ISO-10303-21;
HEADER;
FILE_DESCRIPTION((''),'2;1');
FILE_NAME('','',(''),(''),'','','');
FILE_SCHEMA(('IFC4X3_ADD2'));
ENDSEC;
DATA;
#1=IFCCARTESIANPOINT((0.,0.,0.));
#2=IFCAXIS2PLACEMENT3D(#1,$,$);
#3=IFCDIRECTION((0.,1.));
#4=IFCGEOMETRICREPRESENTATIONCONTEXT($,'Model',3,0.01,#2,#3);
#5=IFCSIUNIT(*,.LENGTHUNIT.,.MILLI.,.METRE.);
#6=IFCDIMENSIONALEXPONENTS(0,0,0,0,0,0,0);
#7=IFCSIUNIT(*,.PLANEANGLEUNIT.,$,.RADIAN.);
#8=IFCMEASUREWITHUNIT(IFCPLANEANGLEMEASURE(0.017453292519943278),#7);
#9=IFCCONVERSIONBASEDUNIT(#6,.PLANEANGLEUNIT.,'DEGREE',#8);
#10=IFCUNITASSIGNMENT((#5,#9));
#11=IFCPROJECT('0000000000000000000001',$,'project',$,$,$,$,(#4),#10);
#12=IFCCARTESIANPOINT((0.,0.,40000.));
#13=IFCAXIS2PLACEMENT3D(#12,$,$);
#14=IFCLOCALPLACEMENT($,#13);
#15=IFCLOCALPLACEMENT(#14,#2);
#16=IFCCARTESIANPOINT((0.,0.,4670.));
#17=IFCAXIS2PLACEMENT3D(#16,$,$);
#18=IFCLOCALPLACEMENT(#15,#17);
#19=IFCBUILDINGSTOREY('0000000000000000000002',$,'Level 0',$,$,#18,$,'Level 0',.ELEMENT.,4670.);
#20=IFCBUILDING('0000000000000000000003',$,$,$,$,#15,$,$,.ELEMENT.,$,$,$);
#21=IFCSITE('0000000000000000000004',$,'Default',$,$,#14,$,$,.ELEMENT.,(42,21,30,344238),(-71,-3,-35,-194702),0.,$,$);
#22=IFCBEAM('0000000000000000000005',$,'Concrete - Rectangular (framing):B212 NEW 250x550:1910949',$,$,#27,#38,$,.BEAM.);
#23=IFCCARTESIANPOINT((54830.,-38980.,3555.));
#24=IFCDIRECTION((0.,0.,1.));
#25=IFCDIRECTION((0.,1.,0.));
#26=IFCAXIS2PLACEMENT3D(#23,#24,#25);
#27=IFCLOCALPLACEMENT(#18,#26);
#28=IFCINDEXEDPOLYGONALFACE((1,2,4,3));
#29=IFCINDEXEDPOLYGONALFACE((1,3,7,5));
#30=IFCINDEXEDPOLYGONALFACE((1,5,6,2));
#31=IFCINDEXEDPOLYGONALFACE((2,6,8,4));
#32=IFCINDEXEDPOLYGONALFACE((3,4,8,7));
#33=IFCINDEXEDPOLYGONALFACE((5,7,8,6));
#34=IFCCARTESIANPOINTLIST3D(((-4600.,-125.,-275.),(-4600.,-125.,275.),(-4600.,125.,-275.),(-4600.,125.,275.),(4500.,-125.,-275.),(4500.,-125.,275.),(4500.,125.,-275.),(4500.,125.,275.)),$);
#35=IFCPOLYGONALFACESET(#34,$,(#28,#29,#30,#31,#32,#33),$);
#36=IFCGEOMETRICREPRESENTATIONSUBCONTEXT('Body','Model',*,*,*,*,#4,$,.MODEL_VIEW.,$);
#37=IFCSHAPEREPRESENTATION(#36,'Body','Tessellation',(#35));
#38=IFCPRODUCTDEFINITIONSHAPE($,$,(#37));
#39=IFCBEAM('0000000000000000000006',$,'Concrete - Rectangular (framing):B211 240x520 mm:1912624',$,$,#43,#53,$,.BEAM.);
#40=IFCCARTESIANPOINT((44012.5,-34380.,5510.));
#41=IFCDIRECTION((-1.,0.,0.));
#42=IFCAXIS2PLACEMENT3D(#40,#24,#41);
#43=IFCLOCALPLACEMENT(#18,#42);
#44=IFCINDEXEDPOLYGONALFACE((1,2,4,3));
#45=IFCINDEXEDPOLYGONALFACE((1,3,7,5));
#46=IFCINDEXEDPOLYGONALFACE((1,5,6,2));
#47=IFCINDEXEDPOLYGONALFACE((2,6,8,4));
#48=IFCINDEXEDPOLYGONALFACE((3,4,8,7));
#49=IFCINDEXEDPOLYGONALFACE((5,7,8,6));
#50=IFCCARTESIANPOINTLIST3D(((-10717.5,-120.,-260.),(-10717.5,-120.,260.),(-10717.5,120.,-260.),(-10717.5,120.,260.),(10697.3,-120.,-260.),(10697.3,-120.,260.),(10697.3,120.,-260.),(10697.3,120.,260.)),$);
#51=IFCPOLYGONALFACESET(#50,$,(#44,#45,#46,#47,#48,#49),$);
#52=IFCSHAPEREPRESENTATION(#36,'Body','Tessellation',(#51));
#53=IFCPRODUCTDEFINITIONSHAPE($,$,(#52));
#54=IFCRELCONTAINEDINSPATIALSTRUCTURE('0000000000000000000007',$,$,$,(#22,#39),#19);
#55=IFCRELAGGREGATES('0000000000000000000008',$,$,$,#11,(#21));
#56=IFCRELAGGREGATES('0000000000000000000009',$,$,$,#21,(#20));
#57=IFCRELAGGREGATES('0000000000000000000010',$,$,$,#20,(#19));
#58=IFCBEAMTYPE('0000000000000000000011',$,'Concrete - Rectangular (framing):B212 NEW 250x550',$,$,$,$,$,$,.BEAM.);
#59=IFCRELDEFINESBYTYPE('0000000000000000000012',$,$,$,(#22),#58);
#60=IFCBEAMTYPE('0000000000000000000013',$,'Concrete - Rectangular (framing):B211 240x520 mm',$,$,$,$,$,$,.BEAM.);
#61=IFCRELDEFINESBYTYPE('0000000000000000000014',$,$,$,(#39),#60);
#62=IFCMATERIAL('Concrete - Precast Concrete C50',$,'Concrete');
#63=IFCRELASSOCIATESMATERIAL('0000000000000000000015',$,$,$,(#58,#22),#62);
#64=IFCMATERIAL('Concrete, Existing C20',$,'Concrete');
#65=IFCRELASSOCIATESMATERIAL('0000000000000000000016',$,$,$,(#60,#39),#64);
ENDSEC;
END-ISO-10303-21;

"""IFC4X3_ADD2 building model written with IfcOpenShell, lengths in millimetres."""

from ifc_helpers import new_model, entity, si_unit, converted_unit, direction, frame, origin, origin_2d_with_axis, place, context, subcontext, project, spatial, rectangle, extrude, source, transform, mapped, material, material_profile, profile_set, profile_usage, type_object, type_shapes, element, save


model = new_model("IFC4X3_ADD2")

# Units and contexts
model_context = context("Model", 3, precision=0.01, world=origin(), true_north=direction((0.0, 1.0)))
body_context = subcontext(model_context, "Body", "Model", "MODEL_VIEW")
ifc_project = project(units=[si_unit("LENGTHUNIT", "METRE", prefix="MILLI"), converted_unit("PLANEANGLEUNIT", "DEGREE", entity("IfcPlaneAngleMeasure", 0.017453292519943278), si_unit("PLANEANGLEUNIT", "RADIAN"), dimensions=[0, 0, 0, 0, 0, 0, 0])], contexts=[model_context])

# Site, building, storey
site_placement = place(None, frame((0.0, 0.0, 40000.0)))
site = spatial("IfcSite", under=ifc_project, at=site_placement, Name="Default", CompositionType="ELEMENT", RefLatitude=(42, 21, 30, 344238), RefLongitude=(-71, -3, -35, -194702), RefElevation=0.0)
building_placement = place(site_placement, origin())
building = spatial("IfcBuilding", under=site, at=building_placement, CompositionType="ELEMENT")
storey_placement = place(building_placement, frame((0.0, 0.0, 4670.0)))
storey = spatial("IfcBuildingStorey", under=building, at=storey_placement, Name="Level 0", LongName="Level 0", CompositionType="ELEMENT", Elevation=4670.0)

# Beams
ifc_material_1 = material(Name="Concrete - Precast Concrete C50", Category="Concrete")
ifc_material_profile_1 = material_profile(ifc_material_1, rectangle(XDim=9200.0, YDim=250.0, at=origin_2d_with_axis()), Name="B212 NEW 250x550")
ifc_profile_set_1 = profile_set([ifc_material_profile_1], Name="B212 NEW 250x550")
ifc_profile_usage_1 = profile_usage(ifc_profile_set_1, cardinal=8)
beam_type_1 = type_object("IfcBeamType", Name="Concrete - Rectangular (framing):B212 NEW 250x550", PredefinedType="BEAM", material=ifc_profile_set_1)
shared_shape_1 = source(origin(), body_context, "Body", "SweptSolid", [
    extrude(rectangle(XDim=9100.0, YDim=250.0, at=origin_2d_with_axis()), frame((-50.0, 0.0, -275.0), z_axis=(0.0, 0.0, 1.0), x_axis=(-1.0, 0.0, 0.0)), (0.0, 0.0, 1.0), 550.0),
])
type_shapes(beam_type_1, [shared_shape_1])
beam_1_placement = place(storey_placement, frame((54830.0, -38980.0, 3555.0), z_axis=(0.0, 0.0, 1.0), x_axis=(0.0, 1.0, 0.0)))
element("IfcBeam", 1, at=beam_1_placement, inside=storey, type_object=beam_type_1, material=ifc_profile_usage_1, Name="Concrete - Rectangular (framing):B212 NEW 250x550:1910949", PredefinedType="BEAM", context=body_context, shape_type="MappedRepresentation", body=[
    mapped(shared_shape_1, transform((0.0, 0.0, 0.0), scale=1.0)),
])
ifc_material_2 = material(Name="Concrete, Existing C20", Category="Concrete")
ifc_material_profile_2 = material_profile(ifc_material_2, rectangle(XDim=21339.8, YDim=240.0, at=origin_2d_with_axis()), Name="B211 240x520 mm")
ifc_profile_set_2 = profile_set([ifc_material_profile_2], Name="B211 240x520 mm")
ifc_profile_usage_2 = profile_usage(ifc_profile_set_2, cardinal=8)
beam_type_2 = type_object("IfcBeamType", Name="Concrete - Rectangular (framing):B211 240x520 mm", PredefinedType="BEAM", material=ifc_profile_set_2)
shared_shape_2 = source(origin(), body_context, "Body", "SweptSolid", [
    extrude(rectangle(XDim=21414.8, YDim=240.0, at=origin_2d_with_axis()), frame((-10.1, 0.0, -260.0), z_axis=(0.0, 0.0, 1.0), x_axis=(-1.0, 0.0, 0.0)), (0.0, 0.0, 1.0), 520.0),
])
type_shapes(beam_type_2, [shared_shape_2])
beam_2_placement = place(storey_placement, frame((44012.5, -34380.0, 5510.0), z_axis=(0.0, 0.0, 1.0), x_axis=(-1.0, 0.0, 0.0)))
element("IfcBeam", 2, at=beam_2_placement, inside=storey, type_object=beam_type_2, material=ifc_profile_usage_2, Name="Concrete - Rectangular (framing):B211 240x520 mm:1912624", PredefinedType="BEAM", context=body_context, shape_type="MappedRepresentation", body=[
    mapped(shared_shape_2, transform((0.0, 0.0, 0.0), scale=1.0)),
])

save(model, "model.ifc")
